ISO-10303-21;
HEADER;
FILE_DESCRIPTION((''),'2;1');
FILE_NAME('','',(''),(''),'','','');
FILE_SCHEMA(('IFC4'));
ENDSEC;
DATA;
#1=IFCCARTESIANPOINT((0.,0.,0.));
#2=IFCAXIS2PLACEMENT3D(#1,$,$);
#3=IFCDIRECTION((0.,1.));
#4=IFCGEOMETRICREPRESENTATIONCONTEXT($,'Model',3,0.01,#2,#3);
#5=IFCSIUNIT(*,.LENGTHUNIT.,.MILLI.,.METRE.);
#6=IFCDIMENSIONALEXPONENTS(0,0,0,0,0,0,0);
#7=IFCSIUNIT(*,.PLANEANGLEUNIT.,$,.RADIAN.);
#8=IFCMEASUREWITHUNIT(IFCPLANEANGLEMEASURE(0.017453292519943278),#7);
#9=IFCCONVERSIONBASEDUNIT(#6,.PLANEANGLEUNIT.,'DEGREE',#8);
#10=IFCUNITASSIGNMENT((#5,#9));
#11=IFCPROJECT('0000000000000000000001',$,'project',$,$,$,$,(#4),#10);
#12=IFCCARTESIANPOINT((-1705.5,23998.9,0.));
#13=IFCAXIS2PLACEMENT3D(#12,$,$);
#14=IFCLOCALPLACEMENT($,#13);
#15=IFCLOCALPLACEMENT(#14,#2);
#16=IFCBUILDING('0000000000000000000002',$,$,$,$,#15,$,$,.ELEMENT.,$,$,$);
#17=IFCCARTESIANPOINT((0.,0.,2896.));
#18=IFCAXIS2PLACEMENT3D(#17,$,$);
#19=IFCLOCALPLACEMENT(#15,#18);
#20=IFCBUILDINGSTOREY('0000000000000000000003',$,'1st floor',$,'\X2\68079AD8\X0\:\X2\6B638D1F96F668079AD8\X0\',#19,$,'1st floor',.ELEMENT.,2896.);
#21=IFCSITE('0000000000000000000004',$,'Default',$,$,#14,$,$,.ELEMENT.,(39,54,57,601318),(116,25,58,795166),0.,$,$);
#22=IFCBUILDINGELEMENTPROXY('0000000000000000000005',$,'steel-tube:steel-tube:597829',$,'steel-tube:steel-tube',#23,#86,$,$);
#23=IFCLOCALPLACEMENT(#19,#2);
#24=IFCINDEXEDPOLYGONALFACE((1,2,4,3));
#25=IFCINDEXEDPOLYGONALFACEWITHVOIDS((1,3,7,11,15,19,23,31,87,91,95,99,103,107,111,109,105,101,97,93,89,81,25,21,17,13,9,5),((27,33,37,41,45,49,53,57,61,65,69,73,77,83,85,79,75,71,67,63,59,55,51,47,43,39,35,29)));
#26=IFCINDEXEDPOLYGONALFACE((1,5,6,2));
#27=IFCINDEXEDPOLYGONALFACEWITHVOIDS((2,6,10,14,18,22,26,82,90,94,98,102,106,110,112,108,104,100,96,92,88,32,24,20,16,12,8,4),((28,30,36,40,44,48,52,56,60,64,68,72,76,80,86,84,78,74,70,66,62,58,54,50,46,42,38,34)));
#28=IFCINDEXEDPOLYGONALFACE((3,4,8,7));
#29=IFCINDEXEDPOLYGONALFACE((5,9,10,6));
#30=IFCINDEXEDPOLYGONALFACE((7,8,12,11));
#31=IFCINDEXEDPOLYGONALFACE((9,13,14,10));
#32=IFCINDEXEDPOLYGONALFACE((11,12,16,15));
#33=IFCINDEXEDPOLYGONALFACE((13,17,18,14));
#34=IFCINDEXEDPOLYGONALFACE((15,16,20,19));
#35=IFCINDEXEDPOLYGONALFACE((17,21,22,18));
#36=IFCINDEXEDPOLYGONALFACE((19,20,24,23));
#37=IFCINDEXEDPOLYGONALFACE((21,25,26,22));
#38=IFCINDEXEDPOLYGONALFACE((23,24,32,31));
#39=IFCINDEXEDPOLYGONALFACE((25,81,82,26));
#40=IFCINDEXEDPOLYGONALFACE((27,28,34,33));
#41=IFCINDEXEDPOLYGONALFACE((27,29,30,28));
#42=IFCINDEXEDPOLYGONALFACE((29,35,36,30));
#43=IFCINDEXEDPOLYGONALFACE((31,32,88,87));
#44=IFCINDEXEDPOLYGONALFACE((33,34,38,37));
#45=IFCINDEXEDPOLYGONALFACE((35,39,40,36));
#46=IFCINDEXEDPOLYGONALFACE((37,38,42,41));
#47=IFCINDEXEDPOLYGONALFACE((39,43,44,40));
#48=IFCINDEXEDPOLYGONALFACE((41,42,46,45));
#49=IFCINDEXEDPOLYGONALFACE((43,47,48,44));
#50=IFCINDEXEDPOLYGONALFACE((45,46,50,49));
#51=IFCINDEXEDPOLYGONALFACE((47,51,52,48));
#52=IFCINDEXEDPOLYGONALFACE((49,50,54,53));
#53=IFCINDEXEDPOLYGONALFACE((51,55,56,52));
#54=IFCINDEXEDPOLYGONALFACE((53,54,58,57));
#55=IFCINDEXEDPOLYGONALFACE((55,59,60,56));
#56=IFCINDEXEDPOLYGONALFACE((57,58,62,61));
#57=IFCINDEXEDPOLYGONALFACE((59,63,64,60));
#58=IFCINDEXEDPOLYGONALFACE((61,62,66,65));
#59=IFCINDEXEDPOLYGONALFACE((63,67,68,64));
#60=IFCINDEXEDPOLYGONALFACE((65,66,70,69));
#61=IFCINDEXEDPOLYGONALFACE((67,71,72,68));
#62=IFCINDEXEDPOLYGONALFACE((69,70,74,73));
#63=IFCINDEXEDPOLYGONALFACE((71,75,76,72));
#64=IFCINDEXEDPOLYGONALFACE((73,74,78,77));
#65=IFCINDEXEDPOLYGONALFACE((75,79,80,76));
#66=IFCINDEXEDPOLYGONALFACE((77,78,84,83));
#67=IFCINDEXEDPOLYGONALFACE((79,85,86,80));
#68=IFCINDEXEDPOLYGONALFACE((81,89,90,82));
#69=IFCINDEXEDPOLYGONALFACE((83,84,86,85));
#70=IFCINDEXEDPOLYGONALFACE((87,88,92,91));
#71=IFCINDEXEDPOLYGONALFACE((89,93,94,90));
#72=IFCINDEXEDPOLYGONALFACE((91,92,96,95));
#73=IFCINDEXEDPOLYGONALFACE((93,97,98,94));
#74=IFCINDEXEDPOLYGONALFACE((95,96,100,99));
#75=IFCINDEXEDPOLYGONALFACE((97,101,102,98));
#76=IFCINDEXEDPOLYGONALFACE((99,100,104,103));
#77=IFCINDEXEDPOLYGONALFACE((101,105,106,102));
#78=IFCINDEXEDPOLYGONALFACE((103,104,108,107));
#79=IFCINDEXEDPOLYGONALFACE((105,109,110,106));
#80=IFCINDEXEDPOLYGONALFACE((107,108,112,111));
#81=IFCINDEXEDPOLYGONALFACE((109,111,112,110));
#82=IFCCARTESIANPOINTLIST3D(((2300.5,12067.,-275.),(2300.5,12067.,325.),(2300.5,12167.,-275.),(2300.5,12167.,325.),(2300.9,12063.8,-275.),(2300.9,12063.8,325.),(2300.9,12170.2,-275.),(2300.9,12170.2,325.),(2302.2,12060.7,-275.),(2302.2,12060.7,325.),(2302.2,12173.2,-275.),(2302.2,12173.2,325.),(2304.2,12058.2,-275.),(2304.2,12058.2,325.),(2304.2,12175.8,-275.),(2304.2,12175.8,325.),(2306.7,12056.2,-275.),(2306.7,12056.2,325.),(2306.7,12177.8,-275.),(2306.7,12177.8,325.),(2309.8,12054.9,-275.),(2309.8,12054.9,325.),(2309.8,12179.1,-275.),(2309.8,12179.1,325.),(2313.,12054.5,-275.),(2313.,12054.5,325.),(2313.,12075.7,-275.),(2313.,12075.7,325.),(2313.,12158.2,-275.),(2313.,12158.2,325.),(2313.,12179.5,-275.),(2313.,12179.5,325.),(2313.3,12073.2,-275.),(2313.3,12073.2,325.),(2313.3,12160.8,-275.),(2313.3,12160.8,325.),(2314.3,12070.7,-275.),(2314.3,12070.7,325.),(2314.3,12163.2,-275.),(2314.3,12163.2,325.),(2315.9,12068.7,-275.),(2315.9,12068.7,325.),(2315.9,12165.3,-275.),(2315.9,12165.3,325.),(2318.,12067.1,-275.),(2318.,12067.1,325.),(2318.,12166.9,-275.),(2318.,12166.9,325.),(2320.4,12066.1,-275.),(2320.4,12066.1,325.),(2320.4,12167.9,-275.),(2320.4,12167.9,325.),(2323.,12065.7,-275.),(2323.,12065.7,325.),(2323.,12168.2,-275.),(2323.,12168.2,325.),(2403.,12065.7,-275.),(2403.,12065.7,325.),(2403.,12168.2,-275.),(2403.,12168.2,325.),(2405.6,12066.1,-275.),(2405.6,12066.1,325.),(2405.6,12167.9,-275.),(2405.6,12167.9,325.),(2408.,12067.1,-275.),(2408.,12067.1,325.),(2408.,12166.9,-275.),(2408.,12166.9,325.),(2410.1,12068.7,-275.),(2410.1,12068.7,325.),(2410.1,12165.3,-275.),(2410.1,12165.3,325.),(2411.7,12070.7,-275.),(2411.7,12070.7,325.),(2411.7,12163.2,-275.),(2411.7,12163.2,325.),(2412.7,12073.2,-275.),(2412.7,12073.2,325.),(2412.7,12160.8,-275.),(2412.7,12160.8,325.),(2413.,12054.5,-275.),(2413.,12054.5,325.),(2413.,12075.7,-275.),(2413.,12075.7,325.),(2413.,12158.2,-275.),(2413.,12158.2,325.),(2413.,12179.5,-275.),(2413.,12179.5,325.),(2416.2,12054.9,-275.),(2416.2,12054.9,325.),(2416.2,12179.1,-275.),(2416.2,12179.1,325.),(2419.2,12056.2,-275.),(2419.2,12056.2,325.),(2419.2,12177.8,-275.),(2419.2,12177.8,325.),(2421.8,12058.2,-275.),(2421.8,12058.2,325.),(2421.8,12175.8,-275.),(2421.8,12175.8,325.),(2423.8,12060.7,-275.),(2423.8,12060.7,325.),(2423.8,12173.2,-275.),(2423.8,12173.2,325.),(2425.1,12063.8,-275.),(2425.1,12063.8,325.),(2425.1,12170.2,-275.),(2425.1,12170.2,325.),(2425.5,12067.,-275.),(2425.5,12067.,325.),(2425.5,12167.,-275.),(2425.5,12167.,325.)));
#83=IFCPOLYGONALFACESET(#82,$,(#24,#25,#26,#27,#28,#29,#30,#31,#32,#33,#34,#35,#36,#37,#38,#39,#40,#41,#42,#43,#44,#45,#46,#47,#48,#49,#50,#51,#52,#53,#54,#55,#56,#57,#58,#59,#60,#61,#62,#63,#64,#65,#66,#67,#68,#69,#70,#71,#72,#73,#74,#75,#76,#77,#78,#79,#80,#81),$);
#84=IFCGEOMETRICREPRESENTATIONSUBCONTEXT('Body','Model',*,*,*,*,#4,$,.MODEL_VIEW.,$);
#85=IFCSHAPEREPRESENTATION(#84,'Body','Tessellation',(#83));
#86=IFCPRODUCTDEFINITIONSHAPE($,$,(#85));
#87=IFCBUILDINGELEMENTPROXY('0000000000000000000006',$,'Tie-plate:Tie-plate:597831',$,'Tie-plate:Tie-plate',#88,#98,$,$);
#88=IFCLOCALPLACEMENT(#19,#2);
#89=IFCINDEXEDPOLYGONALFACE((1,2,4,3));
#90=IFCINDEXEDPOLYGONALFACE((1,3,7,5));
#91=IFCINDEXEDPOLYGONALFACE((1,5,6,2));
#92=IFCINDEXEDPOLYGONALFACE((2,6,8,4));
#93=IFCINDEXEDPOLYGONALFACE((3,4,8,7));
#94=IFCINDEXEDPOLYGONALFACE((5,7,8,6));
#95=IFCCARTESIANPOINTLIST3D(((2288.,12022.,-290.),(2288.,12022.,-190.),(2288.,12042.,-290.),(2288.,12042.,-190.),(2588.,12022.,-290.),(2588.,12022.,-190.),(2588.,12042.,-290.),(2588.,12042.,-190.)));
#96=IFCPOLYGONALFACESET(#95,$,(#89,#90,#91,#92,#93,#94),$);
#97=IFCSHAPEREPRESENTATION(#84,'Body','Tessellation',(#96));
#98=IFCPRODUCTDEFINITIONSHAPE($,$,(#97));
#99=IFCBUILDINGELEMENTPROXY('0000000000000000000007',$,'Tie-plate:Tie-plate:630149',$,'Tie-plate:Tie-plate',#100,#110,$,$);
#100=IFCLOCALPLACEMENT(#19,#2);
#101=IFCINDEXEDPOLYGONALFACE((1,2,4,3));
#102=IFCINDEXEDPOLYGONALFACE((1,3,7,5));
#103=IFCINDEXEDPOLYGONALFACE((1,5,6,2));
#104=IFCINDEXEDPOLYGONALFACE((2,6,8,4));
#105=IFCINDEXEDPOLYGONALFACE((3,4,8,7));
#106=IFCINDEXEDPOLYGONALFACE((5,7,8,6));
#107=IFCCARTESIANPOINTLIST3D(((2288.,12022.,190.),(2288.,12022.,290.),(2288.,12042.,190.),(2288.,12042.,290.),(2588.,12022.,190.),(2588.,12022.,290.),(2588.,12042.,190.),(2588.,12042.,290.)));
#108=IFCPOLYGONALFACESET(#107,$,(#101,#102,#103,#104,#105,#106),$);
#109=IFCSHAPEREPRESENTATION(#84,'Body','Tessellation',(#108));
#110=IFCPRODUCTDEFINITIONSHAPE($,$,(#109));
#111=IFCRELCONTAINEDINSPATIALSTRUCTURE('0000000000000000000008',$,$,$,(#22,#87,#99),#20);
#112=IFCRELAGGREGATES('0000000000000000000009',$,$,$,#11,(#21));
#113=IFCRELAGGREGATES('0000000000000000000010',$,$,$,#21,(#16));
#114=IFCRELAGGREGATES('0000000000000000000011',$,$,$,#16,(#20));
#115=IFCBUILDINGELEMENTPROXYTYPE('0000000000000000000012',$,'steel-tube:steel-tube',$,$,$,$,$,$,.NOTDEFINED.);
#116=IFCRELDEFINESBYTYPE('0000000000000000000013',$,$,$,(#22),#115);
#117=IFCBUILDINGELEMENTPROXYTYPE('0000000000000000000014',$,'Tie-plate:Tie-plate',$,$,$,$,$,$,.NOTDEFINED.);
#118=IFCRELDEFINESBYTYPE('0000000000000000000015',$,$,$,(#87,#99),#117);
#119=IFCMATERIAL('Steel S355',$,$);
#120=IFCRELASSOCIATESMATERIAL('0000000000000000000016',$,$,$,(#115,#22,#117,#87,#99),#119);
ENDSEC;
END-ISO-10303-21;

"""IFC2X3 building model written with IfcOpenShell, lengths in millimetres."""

from ifc_helpers import new_model, entity, si_unit, converted_unit, direction, frame, frame_2d, origin, place, context, subcontext, project, spatial, polyline, circle_curve, parameter, trimmed, segment, composite_curve, rectangle, outline, extrude, source, transform, mapped, material, type_object, type_shapes, element, save


model = new_model("IFC2X3")

# Units and contexts
model_context = context("Model", 3, precision=0.01, world=origin(), true_north=direction((0.0, 1.0)))
body_context = subcontext(model_context, "Body", "Model", "MODEL_VIEW")
ifc_project = project(units=[si_unit("LENGTHUNIT", "METRE", prefix="MILLI"), converted_unit("PLANEANGLEUNIT", "DEGREE", entity("IfcPlaneAngleMeasure", 0.017453292519943278), si_unit("PLANEANGLEUNIT", "RADIAN"), dimensions=[0, 0, 0, 0, 0, 0, 0])], contexts=[model_context])

# Site, building, storey
site_placement = place(None, frame((-1705.5, 23998.9, 0.0)))
site = spatial("IfcSite", under=ifc_project, at=site_placement, Name="Default", CompositionType="ELEMENT", RefLatitude=(39, 54, 57, 601318), RefLongitude=(116, 25, 58, 795166), RefElevation=0.0)
building_placement = place(site_placement, origin())
building = spatial("IfcBuilding", under=site, at=building_placement, CompositionType="ELEMENT")
storey_placement = place(building_placement, frame((0.0, 0.0, 2896.0)))
storey = spatial("IfcBuildingStorey", under=building, at=storey_placement, Name="1st floor", ObjectType="标高:正负零标高", LongName="1st floor", CompositionType="ELEMENT", Elevation=2896.0)

# Shared definitions
ifc_material_1 = material(Name="Steel S355")

# Building element proxies
building_element_proxy_type_1 = type_object("IfcBuildingElementProxyType", Name="steel-tube:steel-tube", PredefinedType="NOTDEFINED", material=ifc_material_1)
shared_shape_1 = source(origin(), body_context, "Body", "SweptSolid", [
    extrude(outline(composite_curve([segment(trimmed(circle_curve(frame_2d((50.0, -50.0), x_axis=(1.0, 0.0)), 12.5), [parameter(270.0)], [parameter(0.0)], True, "PARAMETER"), True, "CONTINUOUS"), segment(polyline([(62.5, -50.0), (62.5, 50.0)]), True, "CONTINUOUS"), segment(trimmed(circle_curve(frame_2d((50.0, 50.0), x_axis=(1.0, 0.0)), 12.5), [parameter(0.0)], [parameter(90.0)], True, "PARAMETER"), True, "CONTINUOUS"), segment(polyline([(50.0, 62.5), (-50.0, 62.5)]), True, "CONTINUOUS"), segment(trimmed(circle_curve(frame_2d((-50.0, 50.0), x_axis=(1.0, 0.0)), 12.5), [parameter(90.0)], [parameter(180.0)], True, "PARAMETER"), True, "CONTINUOUS"), segment(polyline([(-62.5, 50.0), (-62.5, -50.0)]), True, "CONTINUOUS"), segment(trimmed(circle_curve(frame_2d((-50.0, -50.0), x_axis=(1.0, 0.0)), 12.5), [parameter(180.0)], [parameter(270.0)], True, "PARAMETER"), True, "CONTINUOUS"), segment(polyline([(-50.0, -62.5), (50.0, -62.5)]), True, "CONTINUOUS")], self_intersect=False), holes=[composite_curve([segment(trimmed(circle_curve(frame_2d((-41.2, 40.0), x_axis=(1.0, 0.0)), 10.0), [parameter(90.0)], [parameter(180.0)], True, "PARAMETER"), False, "CONTINUOUS"), segment(polyline([(-41.3, 50.0), (41.2, 50.0)]), True, "CONTINUOUS"), segment(trimmed(circle_curve(frame_2d((41.2, 40.0), x_axis=(1.0, 0.0)), 10.0), [parameter(0.0)], [parameter(90.0)], True, "PARAMETER"), False, "CONTINUOUS"), segment(polyline([(51.2, 40.0), (51.2, -40.0)]), True, "CONTINUOUS"), segment(trimmed(circle_curve(frame_2d((41.2, -40.0), x_axis=(1.0, 0.0)), 10.0), [parameter(270.0)], [parameter(360.0)], True, "PARAMETER"), False, "CONTINUOUS"), segment(polyline([(41.2, -50.0), (-41.3, -50.0)]), True, "CONTINUOUS"), segment(trimmed(circle_curve(frame_2d((-41.3, -40.0), x_axis=(1.0, 0.0)), 10.0), [parameter(180.0)], [parameter(270.0)], True, "PARAMETER"), False, "CONTINUOUS"), segment(polyline([(-51.3, -40.0), (-51.3, 40.0)]), True, "CONTINUOUS")], self_intersect=False)]), frame((62.5, 62.5, -175.0)), (0.0, 0.0, 1.0), 600.0),
])
type_shapes(building_element_proxy_type_1, [shared_shape_1])
for number, where, z_axis, x_axis, name in (
    (1, (2300.5, 12179.5, -100.0), (0.0, 0.0, 1.0), (0.0, -1.0, 0.0), "steel-tube:steel-tube:597829"),
):
    element("IfcBuildingElementProxy", number, at=place(storey_placement, frame(where, z_axis=z_axis, x_axis=x_axis)), inside=storey, type_object=building_element_proxy_type_1, material=ifc_material_1, Name=name, ObjectType="steel-tube:steel-tube", context=body_context, shape_type="MappedRepresentation", body=[
        mapped(shared_shape_1, transform((0.0, 0.0, 0.0), scale=1.0)),
    ])
building_element_proxy_type_2 = type_object("IfcBuildingElementProxyType", Name="Tie-plate:Tie-plate", PredefinedType="NOTDEFINED", material=ifc_material_1)
shared_shape_2 = source(origin(), body_context, "Body", "SweptSolid", [
    extrude(rectangle(XDim=300.0, YDim=20.0, at=frame_2d((0.0, 0.0), x_axis=(1.0, 0.0))), frame((150.0, -10.0, 0.0), z_axis=(0.0, 0.0, 1.0), x_axis=(-1.0, 0.0, 0.0)), (0.0, 0.0, 1.0), 100.0),
])
type_shapes(building_element_proxy_type_2, [shared_shape_2])
for number, where, name in (
    (2, (2288.0, 12042.0, -290.0), "Tie-plate:Tie-plate:597831"),
    (3, (2288.0, 12042.0, 190.0), "Tie-plate:Tie-plate:630149"),
):
    element("IfcBuildingElementProxy", number, at=place(storey_placement, frame(where)), inside=storey, type_object=building_element_proxy_type_2, material=ifc_material_1, Name=name, ObjectType="Tie-plate:Tie-plate", context=body_context, shape_type="MappedRepresentation", body=[
        mapped(shared_shape_2, transform((0.0, 0.0, 0.0), scale=1.0)),
    ])

save(model, "model.ifc")
